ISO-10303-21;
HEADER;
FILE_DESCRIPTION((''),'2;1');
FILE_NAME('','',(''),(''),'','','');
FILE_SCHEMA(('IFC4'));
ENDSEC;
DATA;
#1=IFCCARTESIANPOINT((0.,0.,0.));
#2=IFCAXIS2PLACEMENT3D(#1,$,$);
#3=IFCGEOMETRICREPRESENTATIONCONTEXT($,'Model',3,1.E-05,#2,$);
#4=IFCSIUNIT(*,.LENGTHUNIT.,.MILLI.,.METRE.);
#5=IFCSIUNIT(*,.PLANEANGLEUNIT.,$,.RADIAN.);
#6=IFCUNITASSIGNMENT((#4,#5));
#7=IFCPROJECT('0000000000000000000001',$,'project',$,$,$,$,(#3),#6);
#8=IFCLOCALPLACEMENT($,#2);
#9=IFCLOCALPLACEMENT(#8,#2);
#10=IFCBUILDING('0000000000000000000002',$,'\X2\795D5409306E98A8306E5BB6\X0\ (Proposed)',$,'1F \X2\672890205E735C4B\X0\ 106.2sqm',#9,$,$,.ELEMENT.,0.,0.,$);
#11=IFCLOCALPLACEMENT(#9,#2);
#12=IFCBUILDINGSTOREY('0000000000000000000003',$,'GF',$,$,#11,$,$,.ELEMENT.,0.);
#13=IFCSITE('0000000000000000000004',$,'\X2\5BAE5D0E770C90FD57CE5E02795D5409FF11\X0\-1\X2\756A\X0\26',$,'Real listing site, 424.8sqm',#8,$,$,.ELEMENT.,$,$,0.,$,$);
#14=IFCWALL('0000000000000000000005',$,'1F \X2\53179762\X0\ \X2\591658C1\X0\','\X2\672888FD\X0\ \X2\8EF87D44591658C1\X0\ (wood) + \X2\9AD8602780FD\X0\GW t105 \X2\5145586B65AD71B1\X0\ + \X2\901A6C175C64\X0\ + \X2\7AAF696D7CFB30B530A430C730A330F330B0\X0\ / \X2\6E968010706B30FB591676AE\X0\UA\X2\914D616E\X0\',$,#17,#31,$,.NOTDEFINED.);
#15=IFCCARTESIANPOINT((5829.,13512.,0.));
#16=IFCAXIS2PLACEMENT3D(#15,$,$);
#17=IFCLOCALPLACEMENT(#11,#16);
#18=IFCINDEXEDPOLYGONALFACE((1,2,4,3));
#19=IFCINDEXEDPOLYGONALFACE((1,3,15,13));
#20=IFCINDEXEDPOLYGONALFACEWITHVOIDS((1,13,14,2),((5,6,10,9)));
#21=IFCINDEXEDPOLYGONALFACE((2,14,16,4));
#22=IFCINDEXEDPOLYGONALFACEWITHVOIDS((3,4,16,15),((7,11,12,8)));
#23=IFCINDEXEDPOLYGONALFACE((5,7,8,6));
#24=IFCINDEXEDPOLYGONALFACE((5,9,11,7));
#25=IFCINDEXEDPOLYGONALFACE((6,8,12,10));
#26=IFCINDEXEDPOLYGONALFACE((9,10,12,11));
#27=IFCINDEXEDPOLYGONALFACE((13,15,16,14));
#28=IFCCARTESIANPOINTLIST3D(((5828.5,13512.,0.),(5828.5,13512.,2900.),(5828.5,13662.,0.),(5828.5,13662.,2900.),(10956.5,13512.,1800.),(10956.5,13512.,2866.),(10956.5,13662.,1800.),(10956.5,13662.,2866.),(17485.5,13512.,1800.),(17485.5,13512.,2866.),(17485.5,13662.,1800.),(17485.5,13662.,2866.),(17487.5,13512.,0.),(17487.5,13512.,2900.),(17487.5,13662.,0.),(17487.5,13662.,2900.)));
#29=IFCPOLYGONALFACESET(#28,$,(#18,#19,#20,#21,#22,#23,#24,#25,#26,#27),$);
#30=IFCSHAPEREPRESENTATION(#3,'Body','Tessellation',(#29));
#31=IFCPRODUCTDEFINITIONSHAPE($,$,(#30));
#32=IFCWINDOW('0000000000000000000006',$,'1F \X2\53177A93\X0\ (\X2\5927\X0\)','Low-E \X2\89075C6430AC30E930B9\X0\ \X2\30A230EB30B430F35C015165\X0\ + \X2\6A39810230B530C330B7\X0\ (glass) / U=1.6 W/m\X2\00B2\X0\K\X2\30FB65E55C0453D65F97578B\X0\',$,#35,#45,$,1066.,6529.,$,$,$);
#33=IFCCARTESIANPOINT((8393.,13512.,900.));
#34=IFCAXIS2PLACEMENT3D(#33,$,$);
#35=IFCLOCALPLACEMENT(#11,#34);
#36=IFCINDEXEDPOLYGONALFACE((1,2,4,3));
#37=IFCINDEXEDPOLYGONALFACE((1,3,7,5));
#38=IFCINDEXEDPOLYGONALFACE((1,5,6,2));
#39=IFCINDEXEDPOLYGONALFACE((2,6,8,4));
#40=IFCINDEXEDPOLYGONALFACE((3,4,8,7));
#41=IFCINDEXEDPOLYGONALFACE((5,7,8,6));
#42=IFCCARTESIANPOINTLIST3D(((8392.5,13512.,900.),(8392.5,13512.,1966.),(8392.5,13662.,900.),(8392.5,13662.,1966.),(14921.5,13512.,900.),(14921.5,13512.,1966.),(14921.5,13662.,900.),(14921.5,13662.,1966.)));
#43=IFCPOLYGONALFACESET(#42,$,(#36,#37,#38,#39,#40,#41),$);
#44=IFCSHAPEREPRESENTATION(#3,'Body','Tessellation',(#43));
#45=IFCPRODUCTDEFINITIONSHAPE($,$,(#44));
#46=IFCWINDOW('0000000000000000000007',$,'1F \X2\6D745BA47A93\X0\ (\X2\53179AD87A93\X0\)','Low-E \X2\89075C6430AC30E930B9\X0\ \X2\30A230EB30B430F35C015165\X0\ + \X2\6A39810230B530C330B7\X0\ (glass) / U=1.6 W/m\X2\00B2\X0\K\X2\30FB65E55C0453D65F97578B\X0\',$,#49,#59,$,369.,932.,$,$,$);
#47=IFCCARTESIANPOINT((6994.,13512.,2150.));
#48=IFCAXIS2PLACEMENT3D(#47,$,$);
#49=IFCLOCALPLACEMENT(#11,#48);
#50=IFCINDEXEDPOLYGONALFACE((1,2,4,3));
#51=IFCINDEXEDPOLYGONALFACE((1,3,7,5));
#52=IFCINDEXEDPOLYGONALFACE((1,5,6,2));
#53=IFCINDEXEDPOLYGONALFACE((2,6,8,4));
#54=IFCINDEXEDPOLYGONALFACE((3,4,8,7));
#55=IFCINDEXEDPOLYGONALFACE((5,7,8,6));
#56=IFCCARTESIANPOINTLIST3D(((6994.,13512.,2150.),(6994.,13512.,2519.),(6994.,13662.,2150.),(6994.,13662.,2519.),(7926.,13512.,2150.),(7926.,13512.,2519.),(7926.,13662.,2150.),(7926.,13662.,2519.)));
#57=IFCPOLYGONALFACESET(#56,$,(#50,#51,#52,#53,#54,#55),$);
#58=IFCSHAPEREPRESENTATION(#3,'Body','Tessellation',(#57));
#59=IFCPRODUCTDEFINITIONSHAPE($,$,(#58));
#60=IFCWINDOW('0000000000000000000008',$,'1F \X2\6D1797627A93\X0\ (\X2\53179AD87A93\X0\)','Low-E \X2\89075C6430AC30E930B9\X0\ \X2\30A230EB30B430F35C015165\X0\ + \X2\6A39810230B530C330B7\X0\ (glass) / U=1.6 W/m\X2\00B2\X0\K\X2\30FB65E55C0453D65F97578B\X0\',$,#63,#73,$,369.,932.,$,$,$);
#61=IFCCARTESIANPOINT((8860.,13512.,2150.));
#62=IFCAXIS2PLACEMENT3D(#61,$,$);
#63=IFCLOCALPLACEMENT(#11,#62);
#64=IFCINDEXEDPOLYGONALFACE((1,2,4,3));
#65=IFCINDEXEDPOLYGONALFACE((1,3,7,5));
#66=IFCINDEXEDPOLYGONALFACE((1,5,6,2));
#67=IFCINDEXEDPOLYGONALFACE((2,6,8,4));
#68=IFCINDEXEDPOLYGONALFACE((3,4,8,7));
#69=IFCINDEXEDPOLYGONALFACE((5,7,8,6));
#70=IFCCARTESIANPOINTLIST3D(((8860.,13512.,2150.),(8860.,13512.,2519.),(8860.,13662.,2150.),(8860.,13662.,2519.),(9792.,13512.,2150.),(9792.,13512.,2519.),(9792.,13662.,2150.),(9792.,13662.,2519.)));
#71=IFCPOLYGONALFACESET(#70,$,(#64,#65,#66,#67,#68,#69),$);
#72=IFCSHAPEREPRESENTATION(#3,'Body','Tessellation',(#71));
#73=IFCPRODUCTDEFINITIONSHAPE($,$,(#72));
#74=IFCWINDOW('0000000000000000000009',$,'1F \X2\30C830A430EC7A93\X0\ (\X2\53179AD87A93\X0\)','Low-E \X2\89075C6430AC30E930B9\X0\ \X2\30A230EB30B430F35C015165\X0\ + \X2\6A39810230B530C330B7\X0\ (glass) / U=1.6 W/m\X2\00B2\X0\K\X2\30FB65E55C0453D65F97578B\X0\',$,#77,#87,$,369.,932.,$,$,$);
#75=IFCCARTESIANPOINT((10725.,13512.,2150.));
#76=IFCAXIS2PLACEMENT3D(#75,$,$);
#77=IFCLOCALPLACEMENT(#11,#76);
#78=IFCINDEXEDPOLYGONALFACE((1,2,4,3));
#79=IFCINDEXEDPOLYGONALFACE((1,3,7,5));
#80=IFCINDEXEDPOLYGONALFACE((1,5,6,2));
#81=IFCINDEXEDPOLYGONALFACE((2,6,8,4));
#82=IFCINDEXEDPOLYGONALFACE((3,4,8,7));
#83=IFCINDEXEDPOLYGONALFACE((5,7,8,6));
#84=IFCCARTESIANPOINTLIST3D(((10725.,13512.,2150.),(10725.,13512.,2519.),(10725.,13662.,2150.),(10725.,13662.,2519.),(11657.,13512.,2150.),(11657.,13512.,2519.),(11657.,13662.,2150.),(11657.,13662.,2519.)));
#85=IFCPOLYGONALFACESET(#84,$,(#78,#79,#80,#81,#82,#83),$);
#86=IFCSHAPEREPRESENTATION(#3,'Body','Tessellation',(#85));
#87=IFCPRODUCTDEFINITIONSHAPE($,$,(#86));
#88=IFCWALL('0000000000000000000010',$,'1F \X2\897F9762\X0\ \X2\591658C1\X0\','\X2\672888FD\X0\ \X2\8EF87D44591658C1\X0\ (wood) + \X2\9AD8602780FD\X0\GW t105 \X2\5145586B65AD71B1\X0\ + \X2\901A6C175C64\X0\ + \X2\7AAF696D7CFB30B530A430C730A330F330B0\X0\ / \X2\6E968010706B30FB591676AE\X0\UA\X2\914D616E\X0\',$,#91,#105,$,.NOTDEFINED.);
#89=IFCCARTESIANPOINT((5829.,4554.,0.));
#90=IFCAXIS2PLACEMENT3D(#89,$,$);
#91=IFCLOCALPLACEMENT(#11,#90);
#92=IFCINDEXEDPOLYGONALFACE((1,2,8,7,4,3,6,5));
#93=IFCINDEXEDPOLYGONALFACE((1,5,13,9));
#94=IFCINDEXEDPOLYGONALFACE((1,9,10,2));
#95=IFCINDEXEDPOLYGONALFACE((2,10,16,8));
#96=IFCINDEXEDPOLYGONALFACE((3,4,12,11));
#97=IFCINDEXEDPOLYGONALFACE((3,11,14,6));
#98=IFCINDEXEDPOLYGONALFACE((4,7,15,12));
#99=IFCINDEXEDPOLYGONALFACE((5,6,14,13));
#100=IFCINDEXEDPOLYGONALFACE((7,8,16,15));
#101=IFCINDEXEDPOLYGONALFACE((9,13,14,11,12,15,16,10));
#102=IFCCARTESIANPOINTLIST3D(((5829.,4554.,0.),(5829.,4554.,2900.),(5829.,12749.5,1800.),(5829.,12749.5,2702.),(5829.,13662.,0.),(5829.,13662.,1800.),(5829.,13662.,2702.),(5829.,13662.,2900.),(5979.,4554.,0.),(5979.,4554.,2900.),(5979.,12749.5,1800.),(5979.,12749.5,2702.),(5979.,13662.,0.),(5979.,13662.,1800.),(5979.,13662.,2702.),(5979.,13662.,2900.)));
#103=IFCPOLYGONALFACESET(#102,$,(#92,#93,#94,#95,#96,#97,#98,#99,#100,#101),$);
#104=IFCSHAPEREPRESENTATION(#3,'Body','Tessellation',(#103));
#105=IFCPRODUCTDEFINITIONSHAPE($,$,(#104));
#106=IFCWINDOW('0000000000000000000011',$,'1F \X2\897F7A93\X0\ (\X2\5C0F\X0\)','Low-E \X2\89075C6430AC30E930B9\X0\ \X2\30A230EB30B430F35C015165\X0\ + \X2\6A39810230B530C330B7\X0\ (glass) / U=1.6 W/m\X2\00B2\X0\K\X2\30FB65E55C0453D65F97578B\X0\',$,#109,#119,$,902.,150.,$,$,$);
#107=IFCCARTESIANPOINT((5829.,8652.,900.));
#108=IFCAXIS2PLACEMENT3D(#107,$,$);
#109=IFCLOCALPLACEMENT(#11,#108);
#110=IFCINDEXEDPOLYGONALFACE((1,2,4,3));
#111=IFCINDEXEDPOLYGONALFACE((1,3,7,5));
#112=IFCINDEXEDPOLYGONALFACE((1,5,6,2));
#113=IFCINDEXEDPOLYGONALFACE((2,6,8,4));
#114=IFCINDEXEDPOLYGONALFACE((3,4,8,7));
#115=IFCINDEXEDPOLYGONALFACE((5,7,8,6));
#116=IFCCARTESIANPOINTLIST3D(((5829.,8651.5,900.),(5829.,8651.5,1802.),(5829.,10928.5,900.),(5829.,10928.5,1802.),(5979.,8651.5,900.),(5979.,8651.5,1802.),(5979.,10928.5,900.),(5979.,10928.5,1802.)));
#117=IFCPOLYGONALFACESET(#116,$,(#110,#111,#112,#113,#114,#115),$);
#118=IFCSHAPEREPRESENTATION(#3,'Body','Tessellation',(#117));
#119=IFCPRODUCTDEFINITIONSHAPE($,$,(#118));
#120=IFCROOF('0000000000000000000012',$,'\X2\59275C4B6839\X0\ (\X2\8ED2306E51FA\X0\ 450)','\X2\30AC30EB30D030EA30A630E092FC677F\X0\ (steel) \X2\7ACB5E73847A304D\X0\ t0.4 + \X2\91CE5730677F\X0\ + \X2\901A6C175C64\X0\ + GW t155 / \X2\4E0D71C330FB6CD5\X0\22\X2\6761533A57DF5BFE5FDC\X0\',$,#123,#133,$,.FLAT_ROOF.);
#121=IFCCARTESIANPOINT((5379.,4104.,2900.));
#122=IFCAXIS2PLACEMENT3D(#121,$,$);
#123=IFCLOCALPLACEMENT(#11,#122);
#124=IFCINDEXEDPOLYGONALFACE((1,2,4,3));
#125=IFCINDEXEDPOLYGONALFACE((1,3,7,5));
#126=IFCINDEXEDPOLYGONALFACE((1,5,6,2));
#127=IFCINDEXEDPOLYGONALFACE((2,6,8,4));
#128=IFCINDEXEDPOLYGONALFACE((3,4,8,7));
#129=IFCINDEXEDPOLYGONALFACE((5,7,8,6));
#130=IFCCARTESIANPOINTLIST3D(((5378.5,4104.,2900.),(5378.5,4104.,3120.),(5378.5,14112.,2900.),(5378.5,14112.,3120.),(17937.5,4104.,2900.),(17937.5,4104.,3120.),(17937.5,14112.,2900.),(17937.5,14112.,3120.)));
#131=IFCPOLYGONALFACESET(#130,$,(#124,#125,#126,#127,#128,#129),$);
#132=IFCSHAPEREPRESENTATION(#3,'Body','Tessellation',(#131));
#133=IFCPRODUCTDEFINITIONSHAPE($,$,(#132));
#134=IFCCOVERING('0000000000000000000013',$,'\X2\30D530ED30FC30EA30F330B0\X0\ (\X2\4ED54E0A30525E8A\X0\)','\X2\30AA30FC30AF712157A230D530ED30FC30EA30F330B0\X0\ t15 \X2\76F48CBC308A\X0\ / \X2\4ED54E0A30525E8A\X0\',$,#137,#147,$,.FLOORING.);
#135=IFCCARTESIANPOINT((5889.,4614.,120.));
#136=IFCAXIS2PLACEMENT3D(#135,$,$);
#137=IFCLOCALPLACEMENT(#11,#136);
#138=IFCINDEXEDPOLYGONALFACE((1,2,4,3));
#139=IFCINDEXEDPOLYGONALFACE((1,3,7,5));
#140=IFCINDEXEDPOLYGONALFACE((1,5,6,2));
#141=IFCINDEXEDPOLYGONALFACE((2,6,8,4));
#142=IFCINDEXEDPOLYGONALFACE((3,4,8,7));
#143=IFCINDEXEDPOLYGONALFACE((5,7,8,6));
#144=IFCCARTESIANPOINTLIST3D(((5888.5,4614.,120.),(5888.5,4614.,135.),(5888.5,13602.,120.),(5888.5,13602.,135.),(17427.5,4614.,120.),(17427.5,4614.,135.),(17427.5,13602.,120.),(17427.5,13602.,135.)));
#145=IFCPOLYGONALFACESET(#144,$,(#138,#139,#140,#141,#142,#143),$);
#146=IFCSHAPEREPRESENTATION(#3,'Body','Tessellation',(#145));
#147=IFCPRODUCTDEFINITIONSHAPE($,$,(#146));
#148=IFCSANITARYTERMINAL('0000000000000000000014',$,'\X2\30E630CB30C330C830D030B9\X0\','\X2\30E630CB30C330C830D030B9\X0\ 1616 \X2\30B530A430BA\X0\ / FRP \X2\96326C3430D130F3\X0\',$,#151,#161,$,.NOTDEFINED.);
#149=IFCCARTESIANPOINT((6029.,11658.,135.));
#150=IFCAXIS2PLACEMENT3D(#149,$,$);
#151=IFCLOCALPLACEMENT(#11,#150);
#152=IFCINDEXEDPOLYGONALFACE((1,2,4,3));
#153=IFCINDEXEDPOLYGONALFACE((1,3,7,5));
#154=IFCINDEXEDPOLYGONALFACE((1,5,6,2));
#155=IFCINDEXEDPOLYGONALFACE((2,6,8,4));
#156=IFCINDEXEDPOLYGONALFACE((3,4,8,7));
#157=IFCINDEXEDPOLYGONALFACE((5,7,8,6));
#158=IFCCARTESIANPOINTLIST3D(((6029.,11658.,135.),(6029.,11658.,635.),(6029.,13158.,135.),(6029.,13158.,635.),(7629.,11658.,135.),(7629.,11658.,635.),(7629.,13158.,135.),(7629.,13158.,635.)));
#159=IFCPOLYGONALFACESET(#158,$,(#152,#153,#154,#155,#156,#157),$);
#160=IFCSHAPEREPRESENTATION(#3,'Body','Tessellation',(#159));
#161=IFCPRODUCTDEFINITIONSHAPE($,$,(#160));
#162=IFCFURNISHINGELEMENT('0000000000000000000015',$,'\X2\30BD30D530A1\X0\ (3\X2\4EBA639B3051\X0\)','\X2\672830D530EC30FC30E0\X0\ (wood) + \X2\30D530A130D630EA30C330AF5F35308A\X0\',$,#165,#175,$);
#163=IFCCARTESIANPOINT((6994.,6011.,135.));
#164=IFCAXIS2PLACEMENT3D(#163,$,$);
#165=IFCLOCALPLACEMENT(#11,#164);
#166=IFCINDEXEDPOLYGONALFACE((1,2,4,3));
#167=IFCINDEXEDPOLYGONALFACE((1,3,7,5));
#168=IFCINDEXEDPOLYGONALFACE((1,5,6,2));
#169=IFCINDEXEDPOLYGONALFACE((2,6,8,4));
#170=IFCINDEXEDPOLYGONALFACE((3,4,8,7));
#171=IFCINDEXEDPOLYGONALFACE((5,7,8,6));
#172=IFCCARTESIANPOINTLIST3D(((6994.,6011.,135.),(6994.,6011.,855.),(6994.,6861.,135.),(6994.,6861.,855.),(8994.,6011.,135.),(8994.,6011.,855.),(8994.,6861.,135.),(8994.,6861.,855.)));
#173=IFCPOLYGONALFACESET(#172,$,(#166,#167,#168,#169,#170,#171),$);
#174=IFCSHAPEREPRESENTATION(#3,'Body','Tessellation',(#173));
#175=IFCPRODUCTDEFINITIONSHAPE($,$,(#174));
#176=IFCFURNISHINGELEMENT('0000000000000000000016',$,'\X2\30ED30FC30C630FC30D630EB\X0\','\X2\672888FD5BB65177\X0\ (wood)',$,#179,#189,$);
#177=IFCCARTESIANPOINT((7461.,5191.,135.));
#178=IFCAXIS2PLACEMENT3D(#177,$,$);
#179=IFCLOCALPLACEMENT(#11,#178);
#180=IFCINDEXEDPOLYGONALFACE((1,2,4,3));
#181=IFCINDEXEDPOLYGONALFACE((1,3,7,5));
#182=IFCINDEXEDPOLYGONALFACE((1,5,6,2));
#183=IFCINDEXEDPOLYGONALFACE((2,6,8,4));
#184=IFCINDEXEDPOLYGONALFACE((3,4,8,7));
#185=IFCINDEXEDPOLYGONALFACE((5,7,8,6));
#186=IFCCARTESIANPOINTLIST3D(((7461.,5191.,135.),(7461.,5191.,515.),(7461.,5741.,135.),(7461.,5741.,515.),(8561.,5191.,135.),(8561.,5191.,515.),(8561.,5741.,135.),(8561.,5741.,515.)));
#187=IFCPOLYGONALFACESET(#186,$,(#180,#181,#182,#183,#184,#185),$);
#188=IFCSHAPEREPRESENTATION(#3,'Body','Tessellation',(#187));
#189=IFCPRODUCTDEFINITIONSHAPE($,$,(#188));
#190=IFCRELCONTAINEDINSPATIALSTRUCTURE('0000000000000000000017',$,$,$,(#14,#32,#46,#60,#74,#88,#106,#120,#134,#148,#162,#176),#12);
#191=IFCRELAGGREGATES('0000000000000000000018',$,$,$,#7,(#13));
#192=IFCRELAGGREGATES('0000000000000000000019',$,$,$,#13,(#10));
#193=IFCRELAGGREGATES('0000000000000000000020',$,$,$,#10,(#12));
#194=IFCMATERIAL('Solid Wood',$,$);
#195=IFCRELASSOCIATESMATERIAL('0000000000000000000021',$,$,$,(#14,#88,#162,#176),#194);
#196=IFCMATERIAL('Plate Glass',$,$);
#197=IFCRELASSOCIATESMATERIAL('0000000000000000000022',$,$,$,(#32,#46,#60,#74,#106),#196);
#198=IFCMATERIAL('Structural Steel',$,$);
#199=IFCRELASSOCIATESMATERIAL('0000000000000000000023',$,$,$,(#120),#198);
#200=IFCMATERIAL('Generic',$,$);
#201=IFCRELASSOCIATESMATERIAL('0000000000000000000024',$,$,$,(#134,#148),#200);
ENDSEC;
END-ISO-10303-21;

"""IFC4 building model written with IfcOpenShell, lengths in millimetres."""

from ifc_helpers import new_model, si_unit, frame, frame_2d, origin, place, context, project, spatial, rectangle, extrude, material, element, fill, save


model = new_model("IFC4")

# Units and contexts
model_context = context("Model", 3, precision=1e-05, world=origin())
ifc_project = project(units=[si_unit("LENGTHUNIT", "METRE", prefix="MILLI"), si_unit("PLANEANGLEUNIT", "RADIAN")], contexts=[model_context])

# Site, building, storey
site_placement = place(None, origin())
site = spatial("IfcSite", under=ifc_project, at=site_placement, Name="宮崎県都城市祝吉１-1番26", ObjectType="Real listing site, 424.8sqm", CompositionType="ELEMENT", RefElevation=0.0)
building_placement = place(site_placement, origin())
building = spatial("IfcBuilding", under=site, at=building_placement, Name="祝吉の風の家 (Proposed)", ObjectType="1F 木造平屋 106.2sqm", CompositionType="ELEMENT", ElevationOfRefHeight=0.0, ElevationOfTerrain=0.0)
storey_placement = place(building_placement, origin())
storey = spatial("IfcBuildingStorey", under=building, at=storey_placement, Name="GF", CompositionType="ELEMENT", Elevation=0.0)

# Shared definitions
ifc_material_1 = material(Name="Solid Wood")

# Shared definitions
ifc_material_2 = material(Name="Plate Glass")

# Wall, openings, windows
wall_1_placement = place(storey_placement, frame((5829.0, 13512.0, 0.0)))
wall_1 = element("IfcWall", 1, at=wall_1_placement, inside=storey, material=ifc_material_1, Name="1F 北面 外壁", Description="木製 軸組外壁 (wood) + 高性能GW t105 充填断熱 + 通気層 + 窯業系サイディング / 準耐火・外皮UA配慮", PredefinedType="NOTDEFINED", context=model_context, shape_type="SweptSolid", body=[
    extrude(rectangle(XDim=11659.0, YDim=150.0, at=frame_2d((5829.0, 75.0))), frame((5829.0, 13512.0, 0.0)), (0.0, 0.0, 1.0), 2900.0),
])
opening_1_placement = place(storey_placement, frame((8393.0, 13512.0, 900.0)))
opening_1 = element("IfcOpeningElement", 2, at=opening_1_placement, cuts=wall_1, PredefinedType="NOTDEFINED", context=model_context, shape_type="SweptSolid", body=[
    extrude(rectangle(XDim=6529.0, YDim=150.0, at=frame_2d((3264.0, 75.0))), frame((8393.0, 13512.0, 900.0)), (0.0, 0.0, 1.0), 1066.0),
])
opening_2_placement = place(storey_placement, frame((6994.0, 13512.0, 2150.0)))
opening_2 = element("IfcOpeningElement", 3, at=opening_2_placement, cuts=wall_1, PredefinedType="NOTDEFINED", context=model_context, shape_type="SweptSolid", body=[
    extrude(rectangle(XDim=932.0, YDim=150.0, at=frame_2d((466.0, 75.0))), frame((6994.0, 13512.0, 2150.0)), (0.0, 0.0, 1.0), 369.0),
])
opening_3_placement = place(storey_placement, frame((8860.0, 13512.0, 2150.0)))
opening_3 = element("IfcOpeningElement", 4, at=opening_3_placement, cuts=wall_1, PredefinedType="NOTDEFINED", context=model_context, shape_type="SweptSolid", body=[
    extrude(rectangle(XDim=932.0, YDim=150.0, at=frame_2d((466.0, 75.0))), frame((8860.0, 13512.0, 2150.0)), (0.0, 0.0, 1.0), 369.0),
])
opening_4_placement = place(storey_placement, frame((10725.0, 13512.0, 2150.0)))
opening_4 = element("IfcOpeningElement", 5, at=opening_4_placement, cuts=wall_1, PredefinedType="NOTDEFINED", context=model_context, shape_type="SweptSolid", body=[
    extrude(rectangle(XDim=932.0, YDim=150.0, at=frame_2d((466.0, 75.0))), frame((10725.0, 13512.0, 2150.0)), (0.0, 0.0, 1.0), 369.0),
])
window_1_placement = place(storey_placement, frame((8393.0, 13512.0, 900.0)))
window_1 = element("IfcWindow", 6, at=window_1_placement, inside=storey, material=ifc_material_2, Name="1F 北窓 (大)", Description="Low-E 複層ガラス アルゴン封入 + 樹脂サッシ (glass) / U=1.6 W/m²K・日射取得型", OverallHeight=1066.0, OverallWidth=6529.0, context=model_context, shape_type="SweptSolid", body=[
    extrude(rectangle(XDim=6529.0, YDim=150.0, at=frame_2d((3264.0, 75.0))), frame((8393.0, 13512.0, 900.0)), (0.0, 0.0, 1.0), 1066.0),
])
fill(opening_1, window_1)
window_2_placement = place(storey_placement, frame((6994.0, 13512.0, 2150.0)))
window_2 = element("IfcWindow", 7, at=window_2_placement, inside=storey, material=ifc_material_2, Name="1F 浴室窓 (北高窓)", Description="Low-E 複層ガラス アルゴン封入 + 樹脂サッシ (glass) / U=1.6 W/m²K・日射取得型", OverallHeight=369.0, OverallWidth=932.0, context=model_context, shape_type="SweptSolid", body=[
    extrude(rectangle(XDim=932.0, YDim=150.0, at=frame_2d((466.0, 75.0))), frame((6994.0, 13512.0, 2150.0)), (0.0, 0.0, 1.0), 369.0),
])
fill(opening_2, window_2)
window_3_placement = place(storey_placement, frame((8860.0, 13512.0, 2150.0)))
window_3 = element("IfcWindow", 8, at=window_3_placement, inside=storey, material=ifc_material_2, Name="1F 洗面窓 (北高窓)", Description="Low-E 複層ガラス アルゴン封入 + 樹脂サッシ (glass) / U=1.6 W/m²K・日射取得型", OverallHeight=369.0, OverallWidth=932.0, context=model_context, shape_type="SweptSolid", body=[
    extrude(rectangle(XDim=932.0, YDim=150.0, at=frame_2d((466.0, 75.0))), frame((8860.0, 13512.0, 2150.0)), (0.0, 0.0, 1.0), 369.0),
])
fill(opening_3, window_3)
window_4_placement = place(storey_placement, frame((10725.0, 13512.0, 2150.0)))
window_4 = element("IfcWindow", 9, at=window_4_placement, inside=storey, material=ifc_material_2, Name="1F トイレ窓 (北高窓)", Description="Low-E 複層ガラス アルゴン封入 + 樹脂サッシ (glass) / U=1.6 W/m²K・日射取得型", OverallHeight=369.0, OverallWidth=932.0, context=model_context, shape_type="SweptSolid", body=[
    extrude(rectangle(XDim=932.0, YDim=150.0, at=frame_2d((466.0, 75.0))), frame((10725.0, 13512.0, 2150.0)), (0.0, 0.0, 1.0), 369.0),
])
fill(opening_4, window_4)

# Wall, opening, window
wall_2_placement = place(storey_placement, frame((5829.0, 4554.0, 0.0)))
wall_2 = element("IfcWall", 10, at=wall_2_placement, inside=storey, material=ifc_material_1, Name="1F 西面 外壁", Description="木製 軸組外壁 (wood) + 高性能GW t105 充填断熱 + 通気層 + 窯業系サイディング / 準耐火・外皮UA配慮", PredefinedType="NOTDEFINED", context=model_context, shape_type="SweptSolid", body=[
    extrude(rectangle(XDim=150.0, YDim=9108.0, at=frame_2d((75.0, 4554.0))), frame((5829.0, 4554.0, 0.0)), (0.0, 0.0, 1.0), 2900.0),
])
opening_5_placement = place(storey_placement, frame((5829.0, 8652.0, 900.0)))
opening_5 = element("IfcOpeningElement", 11, at=opening_5_placement, cuts=wall_2, PredefinedType="NOTDEFINED", context=model_context, shape_type="SweptSolid", body=[
    extrude(rectangle(XDim=150.0, YDim=2277.0, at=frame_2d((75.0, 1138.0))), frame((5829.0, 8652.0, 900.0)), (0.0, 0.0, 1.0), 902.0),
])
window_5_placement = place(storey_placement, frame((5829.0, 8652.0, 900.0)))
window_5 = element("IfcWindow", 12, at=window_5_placement, inside=storey, material=ifc_material_2, Name="1F 西窓 (小)", Description="Low-E 複層ガラス アルゴン封入 + 樹脂サッシ (glass) / U=1.6 W/m²K・日射取得型", OverallHeight=902.0, OverallWidth=150.0, context=model_context, shape_type="SweptSolid", body=[
    extrude(rectangle(XDim=150.0, YDim=2277.0, at=frame_2d((75.0, 1138.0))), frame((5829.0, 8652.0, 900.0)), (0.0, 0.0, 1.0), 902.0),
])
fill(opening_5, window_5)

# Roof
ifc_material_3 = material(Name="Structural Steel")
roof_placement = place(storey_placement, frame((5379.0, 4104.0, 2900.0)))
element("IfcRoof", 13, at=roof_placement, inside=storey, material=ifc_material_3, Name="大屋根 (軒の出 450)", Description="ガルバリウム鋼板 (steel) 立平葺き t0.4 + 野地板 + 通気層 + GW t155 / 不燃・法22条区域対応", PredefinedType="FLAT_ROOF", context=model_context, shape_type="SweptSolid", body=[
    extrude(rectangle(XDim=12559.0, YDim=10008.0, at=frame_2d((6279.0, 5004.0))), frame((5379.0, 4104.0, 2900.0)), (0.0, 0.0, 1.0), 220.0),
])

# Covering
ifc_material_4 = material(Name="Generic")
covering_placement = place(storey_placement, frame((5889.0, 4614.0, 120.0)))
element("IfcCovering", 14, at=covering_placement, inside=storey, material=ifc_material_4, Name="フローリング (仕上げ床)", Description="オーク無垢フローリング t15 直貼り / 仕上げ床", PredefinedType="FLOORING", context=model_context, shape_type="SweptSolid", body=[
    extrude(rectangle(XDim=11539.0, YDim=8988.0, at=frame_2d((5769.0, 4494.0))), frame((5889.0, 4614.0, 120.0)), (0.0, 0.0, 1.0), 15.0),
])

# Sanitary terminal
sanitary_terminal_placement = place(storey_placement, frame((6029.0, 11658.0, 135.0)))
element("IfcSanitaryTerminal", 15, at=sanitary_terminal_placement, inside=storey, material=ifc_material_4, Name="ユニットバス", Description="ユニットバス 1616 サイズ / FRP 防水パン", PredefinedType="NOTDEFINED", context=model_context, shape_type="SweptSolid", body=[
    extrude(rectangle(XDim=1600.0, YDim=1500.0, at=frame_2d((800.0, 750.0))), frame((6029.0, 11658.0, 135.0)), (0.0, 0.0, 1.0), 500.0),
])

# Furnishing elements
furnishing_1_placement = place(storey_placement, frame((6994.0, 6011.0, 135.0)))
element("IfcFurnishingElement", 16, at=furnishing_1_placement, inside=storey, material=ifc_material_1, Name="ソファ (3人掛け)", Description="木フレーム (wood) + ファブリック張り", context=model_context, shape_type="SweptSolid", body=[
    extrude(rectangle(XDim=2000.0, YDim=850.0, at=frame_2d((1000.0, 425.0))), frame((6994.0, 6011.0, 135.0)), (0.0, 0.0, 1.0), 720.0),
])
furnishing_2_placement = place(storey_placement, frame((7461.0, 5191.0, 135.0)))
element("IfcFurnishingElement", 17, at=furnishing_2_placement, inside=storey, material=ifc_material_1, Name="ローテーブル", Description="木製家具 (wood)", context=model_context, shape_type="SweptSolid", body=[
    extrude(rectangle(XDim=1100.0, YDim=550.0, at=frame_2d((550.0, 275.0))), frame((7461.0, 5191.0, 135.0)), (0.0, 0.0, 1.0), 380.0),
])

save(model, "model.ifc")
